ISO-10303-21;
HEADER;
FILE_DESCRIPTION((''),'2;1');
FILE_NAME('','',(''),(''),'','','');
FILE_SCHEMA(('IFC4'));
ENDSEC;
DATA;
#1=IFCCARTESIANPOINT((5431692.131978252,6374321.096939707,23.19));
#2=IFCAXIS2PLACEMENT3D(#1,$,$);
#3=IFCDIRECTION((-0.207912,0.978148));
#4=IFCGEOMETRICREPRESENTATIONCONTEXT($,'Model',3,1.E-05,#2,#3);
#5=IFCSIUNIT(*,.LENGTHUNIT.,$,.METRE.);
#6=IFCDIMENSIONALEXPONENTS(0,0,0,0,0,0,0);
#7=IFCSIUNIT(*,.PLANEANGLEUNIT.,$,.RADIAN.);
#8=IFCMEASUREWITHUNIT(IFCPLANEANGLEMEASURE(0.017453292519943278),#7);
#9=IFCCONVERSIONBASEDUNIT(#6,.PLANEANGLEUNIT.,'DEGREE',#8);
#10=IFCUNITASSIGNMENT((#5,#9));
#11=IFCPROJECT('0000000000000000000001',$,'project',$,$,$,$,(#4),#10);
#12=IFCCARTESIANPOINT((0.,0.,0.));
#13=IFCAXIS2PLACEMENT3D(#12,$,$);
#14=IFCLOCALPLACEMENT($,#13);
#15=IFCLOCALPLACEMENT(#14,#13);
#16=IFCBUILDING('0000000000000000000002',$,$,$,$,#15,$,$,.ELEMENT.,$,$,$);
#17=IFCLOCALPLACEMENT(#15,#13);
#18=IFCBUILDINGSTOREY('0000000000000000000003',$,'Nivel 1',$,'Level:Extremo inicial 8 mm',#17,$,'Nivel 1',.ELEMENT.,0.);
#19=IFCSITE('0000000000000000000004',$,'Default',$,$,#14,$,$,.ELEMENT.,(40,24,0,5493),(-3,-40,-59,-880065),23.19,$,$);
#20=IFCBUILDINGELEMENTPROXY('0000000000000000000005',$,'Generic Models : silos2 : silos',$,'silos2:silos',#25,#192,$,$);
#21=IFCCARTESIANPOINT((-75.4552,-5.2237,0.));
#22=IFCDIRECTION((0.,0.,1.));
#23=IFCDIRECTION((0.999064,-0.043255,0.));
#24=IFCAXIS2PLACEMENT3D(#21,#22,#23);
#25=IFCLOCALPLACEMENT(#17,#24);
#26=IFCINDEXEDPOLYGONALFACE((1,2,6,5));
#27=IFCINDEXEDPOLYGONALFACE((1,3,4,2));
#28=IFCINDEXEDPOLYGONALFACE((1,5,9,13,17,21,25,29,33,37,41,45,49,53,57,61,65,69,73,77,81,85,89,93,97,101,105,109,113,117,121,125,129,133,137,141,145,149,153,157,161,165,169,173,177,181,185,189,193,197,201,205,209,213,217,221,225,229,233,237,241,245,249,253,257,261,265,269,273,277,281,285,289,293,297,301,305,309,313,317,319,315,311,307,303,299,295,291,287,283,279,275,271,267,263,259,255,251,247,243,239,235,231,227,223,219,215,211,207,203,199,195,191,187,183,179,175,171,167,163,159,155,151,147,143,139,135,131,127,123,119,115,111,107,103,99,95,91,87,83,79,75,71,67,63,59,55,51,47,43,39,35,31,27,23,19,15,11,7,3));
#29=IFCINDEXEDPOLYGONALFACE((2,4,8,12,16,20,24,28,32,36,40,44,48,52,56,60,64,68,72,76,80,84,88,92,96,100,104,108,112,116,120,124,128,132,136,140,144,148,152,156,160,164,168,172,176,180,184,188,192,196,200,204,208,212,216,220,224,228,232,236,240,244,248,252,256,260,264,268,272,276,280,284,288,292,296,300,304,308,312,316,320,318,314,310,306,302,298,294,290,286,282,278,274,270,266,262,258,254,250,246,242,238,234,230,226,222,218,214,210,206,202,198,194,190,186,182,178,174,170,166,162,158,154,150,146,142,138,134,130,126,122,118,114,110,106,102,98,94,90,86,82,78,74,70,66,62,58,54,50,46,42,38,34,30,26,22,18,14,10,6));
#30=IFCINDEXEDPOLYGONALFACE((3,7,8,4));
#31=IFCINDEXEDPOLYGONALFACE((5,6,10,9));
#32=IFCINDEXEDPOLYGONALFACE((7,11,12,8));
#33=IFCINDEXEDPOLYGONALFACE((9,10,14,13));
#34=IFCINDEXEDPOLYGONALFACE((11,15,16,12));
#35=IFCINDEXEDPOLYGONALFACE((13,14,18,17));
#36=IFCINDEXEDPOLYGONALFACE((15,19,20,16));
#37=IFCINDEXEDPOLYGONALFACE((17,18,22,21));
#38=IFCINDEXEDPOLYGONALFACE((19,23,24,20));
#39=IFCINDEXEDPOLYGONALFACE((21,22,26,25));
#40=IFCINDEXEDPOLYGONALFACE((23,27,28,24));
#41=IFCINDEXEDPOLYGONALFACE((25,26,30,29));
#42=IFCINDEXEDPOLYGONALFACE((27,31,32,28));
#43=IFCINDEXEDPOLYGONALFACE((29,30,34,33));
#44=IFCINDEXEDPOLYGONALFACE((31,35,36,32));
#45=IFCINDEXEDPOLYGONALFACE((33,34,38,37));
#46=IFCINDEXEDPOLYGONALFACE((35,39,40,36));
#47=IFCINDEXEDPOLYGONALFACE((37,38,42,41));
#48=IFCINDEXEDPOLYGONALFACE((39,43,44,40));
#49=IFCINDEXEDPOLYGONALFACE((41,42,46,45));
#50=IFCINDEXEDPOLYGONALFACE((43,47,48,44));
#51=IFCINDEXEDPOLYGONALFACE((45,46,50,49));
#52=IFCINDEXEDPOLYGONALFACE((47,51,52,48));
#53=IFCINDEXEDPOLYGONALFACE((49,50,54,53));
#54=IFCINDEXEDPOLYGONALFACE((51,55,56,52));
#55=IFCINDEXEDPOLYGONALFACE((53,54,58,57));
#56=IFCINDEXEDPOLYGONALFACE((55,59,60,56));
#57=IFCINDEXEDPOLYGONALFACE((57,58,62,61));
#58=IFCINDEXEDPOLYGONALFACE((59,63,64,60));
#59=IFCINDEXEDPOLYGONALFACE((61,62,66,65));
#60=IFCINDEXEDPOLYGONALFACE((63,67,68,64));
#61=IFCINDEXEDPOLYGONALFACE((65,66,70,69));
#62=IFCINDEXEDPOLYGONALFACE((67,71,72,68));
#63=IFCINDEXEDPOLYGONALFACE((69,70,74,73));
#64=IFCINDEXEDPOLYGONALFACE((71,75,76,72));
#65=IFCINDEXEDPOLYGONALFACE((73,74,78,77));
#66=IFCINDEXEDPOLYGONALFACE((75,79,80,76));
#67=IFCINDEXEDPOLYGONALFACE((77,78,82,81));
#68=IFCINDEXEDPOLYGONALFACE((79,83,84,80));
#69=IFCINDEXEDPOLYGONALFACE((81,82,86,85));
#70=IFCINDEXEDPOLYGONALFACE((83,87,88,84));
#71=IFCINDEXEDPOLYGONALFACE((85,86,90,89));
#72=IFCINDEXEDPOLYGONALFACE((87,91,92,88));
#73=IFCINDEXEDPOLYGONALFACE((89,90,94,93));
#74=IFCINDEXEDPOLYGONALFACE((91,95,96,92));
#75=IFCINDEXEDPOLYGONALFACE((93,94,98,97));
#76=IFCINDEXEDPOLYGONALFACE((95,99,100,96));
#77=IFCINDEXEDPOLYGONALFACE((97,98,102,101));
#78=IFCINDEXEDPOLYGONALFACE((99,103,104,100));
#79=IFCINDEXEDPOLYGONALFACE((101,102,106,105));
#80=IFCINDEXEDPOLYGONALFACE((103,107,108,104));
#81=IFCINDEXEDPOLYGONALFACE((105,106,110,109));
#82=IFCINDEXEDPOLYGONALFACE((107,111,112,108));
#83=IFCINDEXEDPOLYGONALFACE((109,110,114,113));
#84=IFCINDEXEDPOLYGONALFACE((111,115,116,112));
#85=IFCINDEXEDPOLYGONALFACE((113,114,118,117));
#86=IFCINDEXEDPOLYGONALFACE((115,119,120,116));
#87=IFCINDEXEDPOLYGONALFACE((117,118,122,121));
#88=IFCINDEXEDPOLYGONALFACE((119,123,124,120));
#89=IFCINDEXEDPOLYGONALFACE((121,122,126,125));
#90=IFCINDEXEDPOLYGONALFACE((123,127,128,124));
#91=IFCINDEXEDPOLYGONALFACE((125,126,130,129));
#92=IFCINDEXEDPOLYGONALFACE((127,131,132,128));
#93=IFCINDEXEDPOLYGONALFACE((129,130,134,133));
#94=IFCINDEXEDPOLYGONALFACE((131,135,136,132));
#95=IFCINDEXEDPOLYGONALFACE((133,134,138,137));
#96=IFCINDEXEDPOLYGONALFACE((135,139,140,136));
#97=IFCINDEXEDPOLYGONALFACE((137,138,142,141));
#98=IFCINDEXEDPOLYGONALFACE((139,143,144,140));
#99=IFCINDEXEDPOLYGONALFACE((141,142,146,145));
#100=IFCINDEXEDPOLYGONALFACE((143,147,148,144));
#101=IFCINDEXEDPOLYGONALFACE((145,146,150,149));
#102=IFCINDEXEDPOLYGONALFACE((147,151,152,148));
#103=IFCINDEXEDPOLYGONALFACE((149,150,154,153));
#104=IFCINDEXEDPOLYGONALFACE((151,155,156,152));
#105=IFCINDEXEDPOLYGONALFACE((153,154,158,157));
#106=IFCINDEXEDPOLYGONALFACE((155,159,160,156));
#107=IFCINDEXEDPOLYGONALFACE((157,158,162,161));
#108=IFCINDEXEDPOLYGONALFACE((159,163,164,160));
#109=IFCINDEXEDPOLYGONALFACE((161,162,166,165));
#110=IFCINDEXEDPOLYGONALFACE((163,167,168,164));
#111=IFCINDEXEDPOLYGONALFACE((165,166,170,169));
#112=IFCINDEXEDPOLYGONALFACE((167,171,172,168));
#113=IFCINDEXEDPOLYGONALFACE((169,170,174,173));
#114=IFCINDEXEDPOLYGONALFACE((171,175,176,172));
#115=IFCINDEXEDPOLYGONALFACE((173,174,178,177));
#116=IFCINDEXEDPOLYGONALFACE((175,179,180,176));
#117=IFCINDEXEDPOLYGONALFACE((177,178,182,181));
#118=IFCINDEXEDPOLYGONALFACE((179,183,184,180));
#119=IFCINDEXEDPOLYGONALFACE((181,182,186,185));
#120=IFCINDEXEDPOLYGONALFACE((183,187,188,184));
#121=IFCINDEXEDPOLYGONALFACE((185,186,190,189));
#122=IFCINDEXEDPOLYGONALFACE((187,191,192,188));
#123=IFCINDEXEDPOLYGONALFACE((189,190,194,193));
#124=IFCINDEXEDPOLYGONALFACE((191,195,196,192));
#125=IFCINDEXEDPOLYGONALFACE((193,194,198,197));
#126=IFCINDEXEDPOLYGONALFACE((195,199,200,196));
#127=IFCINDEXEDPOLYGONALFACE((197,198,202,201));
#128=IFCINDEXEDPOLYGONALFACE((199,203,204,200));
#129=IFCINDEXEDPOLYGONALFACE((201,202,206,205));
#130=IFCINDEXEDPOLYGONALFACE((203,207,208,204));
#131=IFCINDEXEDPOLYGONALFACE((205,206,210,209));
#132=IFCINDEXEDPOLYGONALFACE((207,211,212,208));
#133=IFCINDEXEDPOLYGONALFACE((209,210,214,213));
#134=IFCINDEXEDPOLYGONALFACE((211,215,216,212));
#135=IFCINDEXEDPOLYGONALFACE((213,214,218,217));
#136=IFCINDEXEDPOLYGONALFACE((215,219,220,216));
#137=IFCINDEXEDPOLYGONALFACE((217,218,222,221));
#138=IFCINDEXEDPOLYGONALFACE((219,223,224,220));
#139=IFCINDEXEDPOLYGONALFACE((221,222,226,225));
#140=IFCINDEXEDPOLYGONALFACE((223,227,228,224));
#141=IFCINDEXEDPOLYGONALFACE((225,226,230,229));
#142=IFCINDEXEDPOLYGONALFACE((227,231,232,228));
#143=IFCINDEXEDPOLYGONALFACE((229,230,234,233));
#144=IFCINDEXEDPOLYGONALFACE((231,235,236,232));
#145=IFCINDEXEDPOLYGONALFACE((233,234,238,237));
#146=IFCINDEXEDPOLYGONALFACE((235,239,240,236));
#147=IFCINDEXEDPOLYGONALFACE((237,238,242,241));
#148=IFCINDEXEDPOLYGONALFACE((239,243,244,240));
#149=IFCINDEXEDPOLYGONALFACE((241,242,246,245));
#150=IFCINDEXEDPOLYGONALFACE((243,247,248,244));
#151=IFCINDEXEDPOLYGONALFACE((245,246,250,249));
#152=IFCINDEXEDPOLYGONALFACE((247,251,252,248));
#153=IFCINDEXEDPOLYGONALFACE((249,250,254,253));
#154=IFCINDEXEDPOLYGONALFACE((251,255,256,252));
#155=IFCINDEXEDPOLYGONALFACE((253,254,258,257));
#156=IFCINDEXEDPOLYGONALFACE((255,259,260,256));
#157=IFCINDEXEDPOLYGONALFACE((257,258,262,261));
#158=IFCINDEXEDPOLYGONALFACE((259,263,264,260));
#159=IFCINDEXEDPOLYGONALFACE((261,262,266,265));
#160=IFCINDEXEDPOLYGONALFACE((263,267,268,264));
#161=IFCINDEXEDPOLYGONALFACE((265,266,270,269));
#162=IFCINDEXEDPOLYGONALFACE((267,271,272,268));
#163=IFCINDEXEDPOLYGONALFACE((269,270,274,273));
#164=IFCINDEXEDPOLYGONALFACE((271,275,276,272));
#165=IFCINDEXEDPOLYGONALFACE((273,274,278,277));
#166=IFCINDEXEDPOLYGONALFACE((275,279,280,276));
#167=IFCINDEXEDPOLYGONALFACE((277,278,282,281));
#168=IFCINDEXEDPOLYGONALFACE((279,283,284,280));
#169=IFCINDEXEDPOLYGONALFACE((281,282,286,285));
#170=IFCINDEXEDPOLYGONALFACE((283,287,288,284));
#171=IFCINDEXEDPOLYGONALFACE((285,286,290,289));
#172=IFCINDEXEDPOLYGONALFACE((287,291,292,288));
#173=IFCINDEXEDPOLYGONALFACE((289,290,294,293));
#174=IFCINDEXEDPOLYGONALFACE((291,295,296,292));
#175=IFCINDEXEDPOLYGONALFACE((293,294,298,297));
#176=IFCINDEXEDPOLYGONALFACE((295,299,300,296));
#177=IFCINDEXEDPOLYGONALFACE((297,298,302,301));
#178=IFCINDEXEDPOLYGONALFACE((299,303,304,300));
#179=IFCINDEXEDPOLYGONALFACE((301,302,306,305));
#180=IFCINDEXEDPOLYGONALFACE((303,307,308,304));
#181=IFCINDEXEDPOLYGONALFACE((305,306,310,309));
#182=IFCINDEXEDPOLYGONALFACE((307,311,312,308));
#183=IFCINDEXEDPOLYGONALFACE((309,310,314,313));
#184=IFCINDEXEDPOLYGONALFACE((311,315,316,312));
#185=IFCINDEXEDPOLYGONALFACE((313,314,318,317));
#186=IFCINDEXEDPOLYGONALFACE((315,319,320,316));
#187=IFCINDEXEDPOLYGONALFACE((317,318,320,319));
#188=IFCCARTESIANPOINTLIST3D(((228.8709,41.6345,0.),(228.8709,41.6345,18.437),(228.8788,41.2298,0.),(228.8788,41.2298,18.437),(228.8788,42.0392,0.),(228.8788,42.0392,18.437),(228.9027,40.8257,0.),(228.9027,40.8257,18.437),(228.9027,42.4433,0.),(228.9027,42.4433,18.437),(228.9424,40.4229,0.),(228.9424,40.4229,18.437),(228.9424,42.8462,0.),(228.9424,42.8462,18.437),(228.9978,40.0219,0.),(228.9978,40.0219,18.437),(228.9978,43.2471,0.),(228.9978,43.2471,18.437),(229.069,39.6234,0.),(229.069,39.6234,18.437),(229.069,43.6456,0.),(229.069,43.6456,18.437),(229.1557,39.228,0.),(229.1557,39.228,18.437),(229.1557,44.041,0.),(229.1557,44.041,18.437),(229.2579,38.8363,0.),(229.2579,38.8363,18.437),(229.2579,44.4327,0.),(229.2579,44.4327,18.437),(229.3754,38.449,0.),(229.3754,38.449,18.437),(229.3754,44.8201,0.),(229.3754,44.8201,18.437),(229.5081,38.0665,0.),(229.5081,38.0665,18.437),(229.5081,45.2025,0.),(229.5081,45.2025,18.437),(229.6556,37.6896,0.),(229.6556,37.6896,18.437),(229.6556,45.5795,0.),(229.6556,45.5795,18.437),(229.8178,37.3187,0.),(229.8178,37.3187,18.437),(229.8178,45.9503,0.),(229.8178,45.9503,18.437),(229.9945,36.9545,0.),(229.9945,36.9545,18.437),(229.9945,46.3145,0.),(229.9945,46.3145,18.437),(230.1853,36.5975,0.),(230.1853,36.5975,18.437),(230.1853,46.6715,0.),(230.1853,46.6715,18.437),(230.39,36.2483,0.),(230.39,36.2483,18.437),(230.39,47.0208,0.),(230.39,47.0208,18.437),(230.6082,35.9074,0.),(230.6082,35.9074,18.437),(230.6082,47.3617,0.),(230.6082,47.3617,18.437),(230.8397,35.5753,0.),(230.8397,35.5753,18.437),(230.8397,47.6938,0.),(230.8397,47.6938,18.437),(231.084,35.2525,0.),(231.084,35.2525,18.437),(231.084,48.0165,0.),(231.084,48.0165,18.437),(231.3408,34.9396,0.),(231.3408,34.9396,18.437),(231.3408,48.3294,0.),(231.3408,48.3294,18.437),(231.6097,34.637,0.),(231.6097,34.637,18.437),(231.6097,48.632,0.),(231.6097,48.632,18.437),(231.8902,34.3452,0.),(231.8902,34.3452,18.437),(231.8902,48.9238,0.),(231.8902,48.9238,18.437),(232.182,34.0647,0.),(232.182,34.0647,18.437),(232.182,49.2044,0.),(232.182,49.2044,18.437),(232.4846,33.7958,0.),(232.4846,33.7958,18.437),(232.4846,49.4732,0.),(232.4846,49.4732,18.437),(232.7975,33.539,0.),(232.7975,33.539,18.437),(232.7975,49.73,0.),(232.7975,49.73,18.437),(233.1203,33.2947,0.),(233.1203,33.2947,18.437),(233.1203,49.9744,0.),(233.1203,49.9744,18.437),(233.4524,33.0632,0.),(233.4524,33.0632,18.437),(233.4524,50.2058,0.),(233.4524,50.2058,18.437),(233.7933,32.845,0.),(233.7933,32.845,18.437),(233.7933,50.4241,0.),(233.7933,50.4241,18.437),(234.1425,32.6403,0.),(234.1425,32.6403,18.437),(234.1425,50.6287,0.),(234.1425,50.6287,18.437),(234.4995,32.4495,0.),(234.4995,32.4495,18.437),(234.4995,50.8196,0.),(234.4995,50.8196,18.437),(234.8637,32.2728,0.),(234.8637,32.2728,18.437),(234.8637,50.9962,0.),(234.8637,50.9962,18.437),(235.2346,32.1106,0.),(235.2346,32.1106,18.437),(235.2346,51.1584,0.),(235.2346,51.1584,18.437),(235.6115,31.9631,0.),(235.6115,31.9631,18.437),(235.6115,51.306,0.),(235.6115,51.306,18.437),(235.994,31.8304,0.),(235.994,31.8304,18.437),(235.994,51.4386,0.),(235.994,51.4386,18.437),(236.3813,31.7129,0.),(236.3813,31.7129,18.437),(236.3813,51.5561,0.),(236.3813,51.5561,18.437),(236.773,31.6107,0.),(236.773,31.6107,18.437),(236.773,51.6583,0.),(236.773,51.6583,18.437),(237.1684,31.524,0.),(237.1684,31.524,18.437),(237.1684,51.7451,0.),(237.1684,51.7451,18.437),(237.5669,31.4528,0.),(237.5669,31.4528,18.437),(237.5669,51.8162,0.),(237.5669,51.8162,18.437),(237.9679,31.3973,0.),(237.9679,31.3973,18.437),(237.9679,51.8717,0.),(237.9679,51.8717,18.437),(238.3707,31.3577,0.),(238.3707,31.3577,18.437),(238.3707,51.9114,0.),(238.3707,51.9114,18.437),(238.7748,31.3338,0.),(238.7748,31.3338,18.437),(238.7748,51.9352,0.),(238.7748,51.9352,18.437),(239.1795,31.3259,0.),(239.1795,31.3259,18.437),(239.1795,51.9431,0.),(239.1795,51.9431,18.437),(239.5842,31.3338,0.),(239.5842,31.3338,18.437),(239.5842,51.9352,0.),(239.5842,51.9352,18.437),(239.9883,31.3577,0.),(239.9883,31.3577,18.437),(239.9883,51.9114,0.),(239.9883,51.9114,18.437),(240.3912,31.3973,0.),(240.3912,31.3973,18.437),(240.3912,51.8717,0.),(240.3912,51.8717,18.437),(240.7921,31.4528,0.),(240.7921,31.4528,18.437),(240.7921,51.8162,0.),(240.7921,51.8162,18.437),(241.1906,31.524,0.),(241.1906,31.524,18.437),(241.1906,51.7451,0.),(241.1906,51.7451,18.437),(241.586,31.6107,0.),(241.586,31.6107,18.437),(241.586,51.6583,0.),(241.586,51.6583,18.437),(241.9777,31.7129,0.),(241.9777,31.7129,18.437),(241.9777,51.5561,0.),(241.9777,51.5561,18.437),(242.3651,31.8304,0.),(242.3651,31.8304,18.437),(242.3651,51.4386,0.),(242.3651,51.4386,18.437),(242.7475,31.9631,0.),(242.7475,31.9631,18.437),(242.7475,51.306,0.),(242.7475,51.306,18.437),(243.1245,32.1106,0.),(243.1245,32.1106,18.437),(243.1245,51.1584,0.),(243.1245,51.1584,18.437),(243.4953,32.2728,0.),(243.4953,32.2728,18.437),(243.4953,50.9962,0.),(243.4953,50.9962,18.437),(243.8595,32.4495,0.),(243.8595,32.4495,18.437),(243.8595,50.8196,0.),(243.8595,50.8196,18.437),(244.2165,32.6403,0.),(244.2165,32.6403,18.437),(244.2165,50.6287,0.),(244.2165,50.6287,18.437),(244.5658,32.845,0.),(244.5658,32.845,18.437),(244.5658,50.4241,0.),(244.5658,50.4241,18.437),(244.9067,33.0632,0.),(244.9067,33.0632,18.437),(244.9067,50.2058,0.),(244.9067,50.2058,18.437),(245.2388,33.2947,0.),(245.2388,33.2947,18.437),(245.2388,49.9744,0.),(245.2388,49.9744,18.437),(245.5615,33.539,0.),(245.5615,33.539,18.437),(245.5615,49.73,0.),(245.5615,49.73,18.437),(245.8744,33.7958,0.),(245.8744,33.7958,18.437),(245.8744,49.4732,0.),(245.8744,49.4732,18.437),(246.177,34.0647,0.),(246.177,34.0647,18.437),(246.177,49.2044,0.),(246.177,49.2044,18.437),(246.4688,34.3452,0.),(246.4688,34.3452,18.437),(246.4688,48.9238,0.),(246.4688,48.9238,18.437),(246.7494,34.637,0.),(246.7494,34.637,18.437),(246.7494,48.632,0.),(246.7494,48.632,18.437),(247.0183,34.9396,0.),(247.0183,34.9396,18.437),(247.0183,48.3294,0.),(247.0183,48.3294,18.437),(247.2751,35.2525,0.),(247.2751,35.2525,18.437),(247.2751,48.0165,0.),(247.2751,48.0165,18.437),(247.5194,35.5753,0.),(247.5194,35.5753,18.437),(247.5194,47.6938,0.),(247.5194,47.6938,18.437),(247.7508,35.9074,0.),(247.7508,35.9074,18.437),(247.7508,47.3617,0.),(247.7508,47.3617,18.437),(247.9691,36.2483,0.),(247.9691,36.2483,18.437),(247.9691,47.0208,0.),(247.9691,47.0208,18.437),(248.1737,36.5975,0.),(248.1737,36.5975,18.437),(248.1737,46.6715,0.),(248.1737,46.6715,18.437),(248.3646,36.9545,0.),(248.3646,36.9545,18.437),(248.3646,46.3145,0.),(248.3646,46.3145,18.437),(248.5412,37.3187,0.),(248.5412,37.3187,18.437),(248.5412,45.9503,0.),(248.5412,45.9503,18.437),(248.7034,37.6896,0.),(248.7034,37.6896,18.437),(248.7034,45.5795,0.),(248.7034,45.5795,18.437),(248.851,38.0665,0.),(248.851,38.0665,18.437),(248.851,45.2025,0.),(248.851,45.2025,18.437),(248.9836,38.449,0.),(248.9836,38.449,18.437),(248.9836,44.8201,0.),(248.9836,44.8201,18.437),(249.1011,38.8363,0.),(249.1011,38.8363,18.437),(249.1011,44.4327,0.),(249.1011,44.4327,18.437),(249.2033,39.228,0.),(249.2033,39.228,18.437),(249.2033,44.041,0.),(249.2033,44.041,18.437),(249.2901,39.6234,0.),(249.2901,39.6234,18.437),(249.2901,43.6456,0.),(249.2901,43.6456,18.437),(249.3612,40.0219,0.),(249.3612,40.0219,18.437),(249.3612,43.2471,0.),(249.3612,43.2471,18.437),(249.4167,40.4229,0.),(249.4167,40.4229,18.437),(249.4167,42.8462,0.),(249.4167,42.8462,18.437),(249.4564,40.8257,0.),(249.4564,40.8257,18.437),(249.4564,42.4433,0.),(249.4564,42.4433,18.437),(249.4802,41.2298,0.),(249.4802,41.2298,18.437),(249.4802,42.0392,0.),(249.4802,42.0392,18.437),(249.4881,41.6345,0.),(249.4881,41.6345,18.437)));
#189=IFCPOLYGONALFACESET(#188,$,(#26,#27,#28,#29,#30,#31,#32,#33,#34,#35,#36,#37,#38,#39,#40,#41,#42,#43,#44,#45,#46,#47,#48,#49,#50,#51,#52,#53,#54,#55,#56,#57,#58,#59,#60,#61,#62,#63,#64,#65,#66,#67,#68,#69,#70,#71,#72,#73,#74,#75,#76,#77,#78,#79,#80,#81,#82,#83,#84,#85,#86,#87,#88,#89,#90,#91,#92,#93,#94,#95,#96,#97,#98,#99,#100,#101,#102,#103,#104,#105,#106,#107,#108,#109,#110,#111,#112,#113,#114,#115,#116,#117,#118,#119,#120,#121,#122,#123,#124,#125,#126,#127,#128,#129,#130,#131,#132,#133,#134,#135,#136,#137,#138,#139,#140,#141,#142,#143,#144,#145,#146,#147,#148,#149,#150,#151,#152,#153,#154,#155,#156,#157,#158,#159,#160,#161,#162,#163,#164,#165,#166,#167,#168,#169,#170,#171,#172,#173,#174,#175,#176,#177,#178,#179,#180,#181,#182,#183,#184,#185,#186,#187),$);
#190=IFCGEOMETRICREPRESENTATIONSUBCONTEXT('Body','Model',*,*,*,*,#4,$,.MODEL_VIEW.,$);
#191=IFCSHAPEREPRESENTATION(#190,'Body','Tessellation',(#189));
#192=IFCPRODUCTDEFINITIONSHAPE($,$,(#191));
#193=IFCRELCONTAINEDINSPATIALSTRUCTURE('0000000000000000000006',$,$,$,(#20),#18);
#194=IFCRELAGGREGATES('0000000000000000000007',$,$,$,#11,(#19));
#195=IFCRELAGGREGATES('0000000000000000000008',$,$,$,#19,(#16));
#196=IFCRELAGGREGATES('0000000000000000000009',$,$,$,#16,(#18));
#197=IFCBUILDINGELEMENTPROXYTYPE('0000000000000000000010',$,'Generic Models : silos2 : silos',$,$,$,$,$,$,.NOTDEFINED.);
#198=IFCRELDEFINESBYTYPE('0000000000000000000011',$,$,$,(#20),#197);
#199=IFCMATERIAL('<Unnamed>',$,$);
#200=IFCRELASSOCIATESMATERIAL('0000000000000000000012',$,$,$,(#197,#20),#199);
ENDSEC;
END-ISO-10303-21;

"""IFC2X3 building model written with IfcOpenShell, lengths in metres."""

from ifc_helpers import new_model, entity, si_unit, converted_unit, direction, frame, frame_2d, origin, place, context, subcontext, project, spatial, circle, extrude, source, transform, mapped, material, type_object, type_shapes, element, save


model = new_model("IFC2X3")

# Units and contexts
model_context = context("Model", 3, precision=1e-05, world=frame((5431692.131978252, 6374321.096939707, 23.19)), true_north=direction((-0.207912, 0.978148)))
body_context = subcontext(model_context, "Body", "Model", "MODEL_VIEW")
ifc_project = project(units=[si_unit("LENGTHUNIT", "METRE"), converted_unit("PLANEANGLEUNIT", "DEGREE", entity("IfcPlaneAngleMeasure", 0.017453292519943278), si_unit("PLANEANGLEUNIT", "RADIAN"), dimensions=[0, 0, 0, 0, 0, 0, 0])], contexts=[model_context])

# Site, building, storey
site_placement = place(None, origin())
site = spatial("IfcSite", under=ifc_project, at=site_placement, Name="Default", CompositionType="ELEMENT", RefLatitude=(40, 24, 0, 5493), RefLongitude=(-3, -40, -59, -880065), RefElevation=23.19)
building_placement = place(site_placement, origin())
building = spatial("IfcBuilding", under=site, at=building_placement, CompositionType="ELEMENT")
storey_placement = place(building_placement, origin())
storey = spatial("IfcBuildingStorey", under=building, at=storey_placement, Name="Nivel 1", ObjectType="Level:Extremo inicial 8 mm", LongName="Nivel 1", CompositionType="ELEMENT", Elevation=0.0)

# Building element proxy
ifc_material_1 = material(Name="<Unnamed>")
building_element_proxy_type_1 = type_object("IfcBuildingElementProxyType", Name="Generic Models : silos2 : silos", PredefinedType="NOTDEFINED", material=ifc_material_1)
shared_shape_1 = source(origin(), body_context, "Body", "SweptSolid", [
    extrude(circle(Radius=10.3086, at=frame_2d((0.0, 0.0), x_axis=(1.0, 0.0))), frame((239.1795, 41.6345, 0.0)), (0.0, 0.0, 1.0), 18.437),
])
type_shapes(building_element_proxy_type_1, [shared_shape_1])
proxy_1_placement = place(storey_placement, frame((-75.4552, -5.2237, 0.0), z_axis=(0.0, 0.0, 1.0), x_axis=(0.999064, -0.043255, 0.0)))
element("IfcBuildingElementProxy", 1, at=proxy_1_placement, inside=storey, type_object=building_element_proxy_type_1, material=ifc_material_1, Name="Generic Models : silos2 : silos", ObjectType="silos2:silos", context=body_context, shape_type="MappedRepresentation", body=[
    mapped(shared_shape_1, transform((0.0, 0.0, 0.0), scale=1.0)),
])

save(model, "model.ifc")
